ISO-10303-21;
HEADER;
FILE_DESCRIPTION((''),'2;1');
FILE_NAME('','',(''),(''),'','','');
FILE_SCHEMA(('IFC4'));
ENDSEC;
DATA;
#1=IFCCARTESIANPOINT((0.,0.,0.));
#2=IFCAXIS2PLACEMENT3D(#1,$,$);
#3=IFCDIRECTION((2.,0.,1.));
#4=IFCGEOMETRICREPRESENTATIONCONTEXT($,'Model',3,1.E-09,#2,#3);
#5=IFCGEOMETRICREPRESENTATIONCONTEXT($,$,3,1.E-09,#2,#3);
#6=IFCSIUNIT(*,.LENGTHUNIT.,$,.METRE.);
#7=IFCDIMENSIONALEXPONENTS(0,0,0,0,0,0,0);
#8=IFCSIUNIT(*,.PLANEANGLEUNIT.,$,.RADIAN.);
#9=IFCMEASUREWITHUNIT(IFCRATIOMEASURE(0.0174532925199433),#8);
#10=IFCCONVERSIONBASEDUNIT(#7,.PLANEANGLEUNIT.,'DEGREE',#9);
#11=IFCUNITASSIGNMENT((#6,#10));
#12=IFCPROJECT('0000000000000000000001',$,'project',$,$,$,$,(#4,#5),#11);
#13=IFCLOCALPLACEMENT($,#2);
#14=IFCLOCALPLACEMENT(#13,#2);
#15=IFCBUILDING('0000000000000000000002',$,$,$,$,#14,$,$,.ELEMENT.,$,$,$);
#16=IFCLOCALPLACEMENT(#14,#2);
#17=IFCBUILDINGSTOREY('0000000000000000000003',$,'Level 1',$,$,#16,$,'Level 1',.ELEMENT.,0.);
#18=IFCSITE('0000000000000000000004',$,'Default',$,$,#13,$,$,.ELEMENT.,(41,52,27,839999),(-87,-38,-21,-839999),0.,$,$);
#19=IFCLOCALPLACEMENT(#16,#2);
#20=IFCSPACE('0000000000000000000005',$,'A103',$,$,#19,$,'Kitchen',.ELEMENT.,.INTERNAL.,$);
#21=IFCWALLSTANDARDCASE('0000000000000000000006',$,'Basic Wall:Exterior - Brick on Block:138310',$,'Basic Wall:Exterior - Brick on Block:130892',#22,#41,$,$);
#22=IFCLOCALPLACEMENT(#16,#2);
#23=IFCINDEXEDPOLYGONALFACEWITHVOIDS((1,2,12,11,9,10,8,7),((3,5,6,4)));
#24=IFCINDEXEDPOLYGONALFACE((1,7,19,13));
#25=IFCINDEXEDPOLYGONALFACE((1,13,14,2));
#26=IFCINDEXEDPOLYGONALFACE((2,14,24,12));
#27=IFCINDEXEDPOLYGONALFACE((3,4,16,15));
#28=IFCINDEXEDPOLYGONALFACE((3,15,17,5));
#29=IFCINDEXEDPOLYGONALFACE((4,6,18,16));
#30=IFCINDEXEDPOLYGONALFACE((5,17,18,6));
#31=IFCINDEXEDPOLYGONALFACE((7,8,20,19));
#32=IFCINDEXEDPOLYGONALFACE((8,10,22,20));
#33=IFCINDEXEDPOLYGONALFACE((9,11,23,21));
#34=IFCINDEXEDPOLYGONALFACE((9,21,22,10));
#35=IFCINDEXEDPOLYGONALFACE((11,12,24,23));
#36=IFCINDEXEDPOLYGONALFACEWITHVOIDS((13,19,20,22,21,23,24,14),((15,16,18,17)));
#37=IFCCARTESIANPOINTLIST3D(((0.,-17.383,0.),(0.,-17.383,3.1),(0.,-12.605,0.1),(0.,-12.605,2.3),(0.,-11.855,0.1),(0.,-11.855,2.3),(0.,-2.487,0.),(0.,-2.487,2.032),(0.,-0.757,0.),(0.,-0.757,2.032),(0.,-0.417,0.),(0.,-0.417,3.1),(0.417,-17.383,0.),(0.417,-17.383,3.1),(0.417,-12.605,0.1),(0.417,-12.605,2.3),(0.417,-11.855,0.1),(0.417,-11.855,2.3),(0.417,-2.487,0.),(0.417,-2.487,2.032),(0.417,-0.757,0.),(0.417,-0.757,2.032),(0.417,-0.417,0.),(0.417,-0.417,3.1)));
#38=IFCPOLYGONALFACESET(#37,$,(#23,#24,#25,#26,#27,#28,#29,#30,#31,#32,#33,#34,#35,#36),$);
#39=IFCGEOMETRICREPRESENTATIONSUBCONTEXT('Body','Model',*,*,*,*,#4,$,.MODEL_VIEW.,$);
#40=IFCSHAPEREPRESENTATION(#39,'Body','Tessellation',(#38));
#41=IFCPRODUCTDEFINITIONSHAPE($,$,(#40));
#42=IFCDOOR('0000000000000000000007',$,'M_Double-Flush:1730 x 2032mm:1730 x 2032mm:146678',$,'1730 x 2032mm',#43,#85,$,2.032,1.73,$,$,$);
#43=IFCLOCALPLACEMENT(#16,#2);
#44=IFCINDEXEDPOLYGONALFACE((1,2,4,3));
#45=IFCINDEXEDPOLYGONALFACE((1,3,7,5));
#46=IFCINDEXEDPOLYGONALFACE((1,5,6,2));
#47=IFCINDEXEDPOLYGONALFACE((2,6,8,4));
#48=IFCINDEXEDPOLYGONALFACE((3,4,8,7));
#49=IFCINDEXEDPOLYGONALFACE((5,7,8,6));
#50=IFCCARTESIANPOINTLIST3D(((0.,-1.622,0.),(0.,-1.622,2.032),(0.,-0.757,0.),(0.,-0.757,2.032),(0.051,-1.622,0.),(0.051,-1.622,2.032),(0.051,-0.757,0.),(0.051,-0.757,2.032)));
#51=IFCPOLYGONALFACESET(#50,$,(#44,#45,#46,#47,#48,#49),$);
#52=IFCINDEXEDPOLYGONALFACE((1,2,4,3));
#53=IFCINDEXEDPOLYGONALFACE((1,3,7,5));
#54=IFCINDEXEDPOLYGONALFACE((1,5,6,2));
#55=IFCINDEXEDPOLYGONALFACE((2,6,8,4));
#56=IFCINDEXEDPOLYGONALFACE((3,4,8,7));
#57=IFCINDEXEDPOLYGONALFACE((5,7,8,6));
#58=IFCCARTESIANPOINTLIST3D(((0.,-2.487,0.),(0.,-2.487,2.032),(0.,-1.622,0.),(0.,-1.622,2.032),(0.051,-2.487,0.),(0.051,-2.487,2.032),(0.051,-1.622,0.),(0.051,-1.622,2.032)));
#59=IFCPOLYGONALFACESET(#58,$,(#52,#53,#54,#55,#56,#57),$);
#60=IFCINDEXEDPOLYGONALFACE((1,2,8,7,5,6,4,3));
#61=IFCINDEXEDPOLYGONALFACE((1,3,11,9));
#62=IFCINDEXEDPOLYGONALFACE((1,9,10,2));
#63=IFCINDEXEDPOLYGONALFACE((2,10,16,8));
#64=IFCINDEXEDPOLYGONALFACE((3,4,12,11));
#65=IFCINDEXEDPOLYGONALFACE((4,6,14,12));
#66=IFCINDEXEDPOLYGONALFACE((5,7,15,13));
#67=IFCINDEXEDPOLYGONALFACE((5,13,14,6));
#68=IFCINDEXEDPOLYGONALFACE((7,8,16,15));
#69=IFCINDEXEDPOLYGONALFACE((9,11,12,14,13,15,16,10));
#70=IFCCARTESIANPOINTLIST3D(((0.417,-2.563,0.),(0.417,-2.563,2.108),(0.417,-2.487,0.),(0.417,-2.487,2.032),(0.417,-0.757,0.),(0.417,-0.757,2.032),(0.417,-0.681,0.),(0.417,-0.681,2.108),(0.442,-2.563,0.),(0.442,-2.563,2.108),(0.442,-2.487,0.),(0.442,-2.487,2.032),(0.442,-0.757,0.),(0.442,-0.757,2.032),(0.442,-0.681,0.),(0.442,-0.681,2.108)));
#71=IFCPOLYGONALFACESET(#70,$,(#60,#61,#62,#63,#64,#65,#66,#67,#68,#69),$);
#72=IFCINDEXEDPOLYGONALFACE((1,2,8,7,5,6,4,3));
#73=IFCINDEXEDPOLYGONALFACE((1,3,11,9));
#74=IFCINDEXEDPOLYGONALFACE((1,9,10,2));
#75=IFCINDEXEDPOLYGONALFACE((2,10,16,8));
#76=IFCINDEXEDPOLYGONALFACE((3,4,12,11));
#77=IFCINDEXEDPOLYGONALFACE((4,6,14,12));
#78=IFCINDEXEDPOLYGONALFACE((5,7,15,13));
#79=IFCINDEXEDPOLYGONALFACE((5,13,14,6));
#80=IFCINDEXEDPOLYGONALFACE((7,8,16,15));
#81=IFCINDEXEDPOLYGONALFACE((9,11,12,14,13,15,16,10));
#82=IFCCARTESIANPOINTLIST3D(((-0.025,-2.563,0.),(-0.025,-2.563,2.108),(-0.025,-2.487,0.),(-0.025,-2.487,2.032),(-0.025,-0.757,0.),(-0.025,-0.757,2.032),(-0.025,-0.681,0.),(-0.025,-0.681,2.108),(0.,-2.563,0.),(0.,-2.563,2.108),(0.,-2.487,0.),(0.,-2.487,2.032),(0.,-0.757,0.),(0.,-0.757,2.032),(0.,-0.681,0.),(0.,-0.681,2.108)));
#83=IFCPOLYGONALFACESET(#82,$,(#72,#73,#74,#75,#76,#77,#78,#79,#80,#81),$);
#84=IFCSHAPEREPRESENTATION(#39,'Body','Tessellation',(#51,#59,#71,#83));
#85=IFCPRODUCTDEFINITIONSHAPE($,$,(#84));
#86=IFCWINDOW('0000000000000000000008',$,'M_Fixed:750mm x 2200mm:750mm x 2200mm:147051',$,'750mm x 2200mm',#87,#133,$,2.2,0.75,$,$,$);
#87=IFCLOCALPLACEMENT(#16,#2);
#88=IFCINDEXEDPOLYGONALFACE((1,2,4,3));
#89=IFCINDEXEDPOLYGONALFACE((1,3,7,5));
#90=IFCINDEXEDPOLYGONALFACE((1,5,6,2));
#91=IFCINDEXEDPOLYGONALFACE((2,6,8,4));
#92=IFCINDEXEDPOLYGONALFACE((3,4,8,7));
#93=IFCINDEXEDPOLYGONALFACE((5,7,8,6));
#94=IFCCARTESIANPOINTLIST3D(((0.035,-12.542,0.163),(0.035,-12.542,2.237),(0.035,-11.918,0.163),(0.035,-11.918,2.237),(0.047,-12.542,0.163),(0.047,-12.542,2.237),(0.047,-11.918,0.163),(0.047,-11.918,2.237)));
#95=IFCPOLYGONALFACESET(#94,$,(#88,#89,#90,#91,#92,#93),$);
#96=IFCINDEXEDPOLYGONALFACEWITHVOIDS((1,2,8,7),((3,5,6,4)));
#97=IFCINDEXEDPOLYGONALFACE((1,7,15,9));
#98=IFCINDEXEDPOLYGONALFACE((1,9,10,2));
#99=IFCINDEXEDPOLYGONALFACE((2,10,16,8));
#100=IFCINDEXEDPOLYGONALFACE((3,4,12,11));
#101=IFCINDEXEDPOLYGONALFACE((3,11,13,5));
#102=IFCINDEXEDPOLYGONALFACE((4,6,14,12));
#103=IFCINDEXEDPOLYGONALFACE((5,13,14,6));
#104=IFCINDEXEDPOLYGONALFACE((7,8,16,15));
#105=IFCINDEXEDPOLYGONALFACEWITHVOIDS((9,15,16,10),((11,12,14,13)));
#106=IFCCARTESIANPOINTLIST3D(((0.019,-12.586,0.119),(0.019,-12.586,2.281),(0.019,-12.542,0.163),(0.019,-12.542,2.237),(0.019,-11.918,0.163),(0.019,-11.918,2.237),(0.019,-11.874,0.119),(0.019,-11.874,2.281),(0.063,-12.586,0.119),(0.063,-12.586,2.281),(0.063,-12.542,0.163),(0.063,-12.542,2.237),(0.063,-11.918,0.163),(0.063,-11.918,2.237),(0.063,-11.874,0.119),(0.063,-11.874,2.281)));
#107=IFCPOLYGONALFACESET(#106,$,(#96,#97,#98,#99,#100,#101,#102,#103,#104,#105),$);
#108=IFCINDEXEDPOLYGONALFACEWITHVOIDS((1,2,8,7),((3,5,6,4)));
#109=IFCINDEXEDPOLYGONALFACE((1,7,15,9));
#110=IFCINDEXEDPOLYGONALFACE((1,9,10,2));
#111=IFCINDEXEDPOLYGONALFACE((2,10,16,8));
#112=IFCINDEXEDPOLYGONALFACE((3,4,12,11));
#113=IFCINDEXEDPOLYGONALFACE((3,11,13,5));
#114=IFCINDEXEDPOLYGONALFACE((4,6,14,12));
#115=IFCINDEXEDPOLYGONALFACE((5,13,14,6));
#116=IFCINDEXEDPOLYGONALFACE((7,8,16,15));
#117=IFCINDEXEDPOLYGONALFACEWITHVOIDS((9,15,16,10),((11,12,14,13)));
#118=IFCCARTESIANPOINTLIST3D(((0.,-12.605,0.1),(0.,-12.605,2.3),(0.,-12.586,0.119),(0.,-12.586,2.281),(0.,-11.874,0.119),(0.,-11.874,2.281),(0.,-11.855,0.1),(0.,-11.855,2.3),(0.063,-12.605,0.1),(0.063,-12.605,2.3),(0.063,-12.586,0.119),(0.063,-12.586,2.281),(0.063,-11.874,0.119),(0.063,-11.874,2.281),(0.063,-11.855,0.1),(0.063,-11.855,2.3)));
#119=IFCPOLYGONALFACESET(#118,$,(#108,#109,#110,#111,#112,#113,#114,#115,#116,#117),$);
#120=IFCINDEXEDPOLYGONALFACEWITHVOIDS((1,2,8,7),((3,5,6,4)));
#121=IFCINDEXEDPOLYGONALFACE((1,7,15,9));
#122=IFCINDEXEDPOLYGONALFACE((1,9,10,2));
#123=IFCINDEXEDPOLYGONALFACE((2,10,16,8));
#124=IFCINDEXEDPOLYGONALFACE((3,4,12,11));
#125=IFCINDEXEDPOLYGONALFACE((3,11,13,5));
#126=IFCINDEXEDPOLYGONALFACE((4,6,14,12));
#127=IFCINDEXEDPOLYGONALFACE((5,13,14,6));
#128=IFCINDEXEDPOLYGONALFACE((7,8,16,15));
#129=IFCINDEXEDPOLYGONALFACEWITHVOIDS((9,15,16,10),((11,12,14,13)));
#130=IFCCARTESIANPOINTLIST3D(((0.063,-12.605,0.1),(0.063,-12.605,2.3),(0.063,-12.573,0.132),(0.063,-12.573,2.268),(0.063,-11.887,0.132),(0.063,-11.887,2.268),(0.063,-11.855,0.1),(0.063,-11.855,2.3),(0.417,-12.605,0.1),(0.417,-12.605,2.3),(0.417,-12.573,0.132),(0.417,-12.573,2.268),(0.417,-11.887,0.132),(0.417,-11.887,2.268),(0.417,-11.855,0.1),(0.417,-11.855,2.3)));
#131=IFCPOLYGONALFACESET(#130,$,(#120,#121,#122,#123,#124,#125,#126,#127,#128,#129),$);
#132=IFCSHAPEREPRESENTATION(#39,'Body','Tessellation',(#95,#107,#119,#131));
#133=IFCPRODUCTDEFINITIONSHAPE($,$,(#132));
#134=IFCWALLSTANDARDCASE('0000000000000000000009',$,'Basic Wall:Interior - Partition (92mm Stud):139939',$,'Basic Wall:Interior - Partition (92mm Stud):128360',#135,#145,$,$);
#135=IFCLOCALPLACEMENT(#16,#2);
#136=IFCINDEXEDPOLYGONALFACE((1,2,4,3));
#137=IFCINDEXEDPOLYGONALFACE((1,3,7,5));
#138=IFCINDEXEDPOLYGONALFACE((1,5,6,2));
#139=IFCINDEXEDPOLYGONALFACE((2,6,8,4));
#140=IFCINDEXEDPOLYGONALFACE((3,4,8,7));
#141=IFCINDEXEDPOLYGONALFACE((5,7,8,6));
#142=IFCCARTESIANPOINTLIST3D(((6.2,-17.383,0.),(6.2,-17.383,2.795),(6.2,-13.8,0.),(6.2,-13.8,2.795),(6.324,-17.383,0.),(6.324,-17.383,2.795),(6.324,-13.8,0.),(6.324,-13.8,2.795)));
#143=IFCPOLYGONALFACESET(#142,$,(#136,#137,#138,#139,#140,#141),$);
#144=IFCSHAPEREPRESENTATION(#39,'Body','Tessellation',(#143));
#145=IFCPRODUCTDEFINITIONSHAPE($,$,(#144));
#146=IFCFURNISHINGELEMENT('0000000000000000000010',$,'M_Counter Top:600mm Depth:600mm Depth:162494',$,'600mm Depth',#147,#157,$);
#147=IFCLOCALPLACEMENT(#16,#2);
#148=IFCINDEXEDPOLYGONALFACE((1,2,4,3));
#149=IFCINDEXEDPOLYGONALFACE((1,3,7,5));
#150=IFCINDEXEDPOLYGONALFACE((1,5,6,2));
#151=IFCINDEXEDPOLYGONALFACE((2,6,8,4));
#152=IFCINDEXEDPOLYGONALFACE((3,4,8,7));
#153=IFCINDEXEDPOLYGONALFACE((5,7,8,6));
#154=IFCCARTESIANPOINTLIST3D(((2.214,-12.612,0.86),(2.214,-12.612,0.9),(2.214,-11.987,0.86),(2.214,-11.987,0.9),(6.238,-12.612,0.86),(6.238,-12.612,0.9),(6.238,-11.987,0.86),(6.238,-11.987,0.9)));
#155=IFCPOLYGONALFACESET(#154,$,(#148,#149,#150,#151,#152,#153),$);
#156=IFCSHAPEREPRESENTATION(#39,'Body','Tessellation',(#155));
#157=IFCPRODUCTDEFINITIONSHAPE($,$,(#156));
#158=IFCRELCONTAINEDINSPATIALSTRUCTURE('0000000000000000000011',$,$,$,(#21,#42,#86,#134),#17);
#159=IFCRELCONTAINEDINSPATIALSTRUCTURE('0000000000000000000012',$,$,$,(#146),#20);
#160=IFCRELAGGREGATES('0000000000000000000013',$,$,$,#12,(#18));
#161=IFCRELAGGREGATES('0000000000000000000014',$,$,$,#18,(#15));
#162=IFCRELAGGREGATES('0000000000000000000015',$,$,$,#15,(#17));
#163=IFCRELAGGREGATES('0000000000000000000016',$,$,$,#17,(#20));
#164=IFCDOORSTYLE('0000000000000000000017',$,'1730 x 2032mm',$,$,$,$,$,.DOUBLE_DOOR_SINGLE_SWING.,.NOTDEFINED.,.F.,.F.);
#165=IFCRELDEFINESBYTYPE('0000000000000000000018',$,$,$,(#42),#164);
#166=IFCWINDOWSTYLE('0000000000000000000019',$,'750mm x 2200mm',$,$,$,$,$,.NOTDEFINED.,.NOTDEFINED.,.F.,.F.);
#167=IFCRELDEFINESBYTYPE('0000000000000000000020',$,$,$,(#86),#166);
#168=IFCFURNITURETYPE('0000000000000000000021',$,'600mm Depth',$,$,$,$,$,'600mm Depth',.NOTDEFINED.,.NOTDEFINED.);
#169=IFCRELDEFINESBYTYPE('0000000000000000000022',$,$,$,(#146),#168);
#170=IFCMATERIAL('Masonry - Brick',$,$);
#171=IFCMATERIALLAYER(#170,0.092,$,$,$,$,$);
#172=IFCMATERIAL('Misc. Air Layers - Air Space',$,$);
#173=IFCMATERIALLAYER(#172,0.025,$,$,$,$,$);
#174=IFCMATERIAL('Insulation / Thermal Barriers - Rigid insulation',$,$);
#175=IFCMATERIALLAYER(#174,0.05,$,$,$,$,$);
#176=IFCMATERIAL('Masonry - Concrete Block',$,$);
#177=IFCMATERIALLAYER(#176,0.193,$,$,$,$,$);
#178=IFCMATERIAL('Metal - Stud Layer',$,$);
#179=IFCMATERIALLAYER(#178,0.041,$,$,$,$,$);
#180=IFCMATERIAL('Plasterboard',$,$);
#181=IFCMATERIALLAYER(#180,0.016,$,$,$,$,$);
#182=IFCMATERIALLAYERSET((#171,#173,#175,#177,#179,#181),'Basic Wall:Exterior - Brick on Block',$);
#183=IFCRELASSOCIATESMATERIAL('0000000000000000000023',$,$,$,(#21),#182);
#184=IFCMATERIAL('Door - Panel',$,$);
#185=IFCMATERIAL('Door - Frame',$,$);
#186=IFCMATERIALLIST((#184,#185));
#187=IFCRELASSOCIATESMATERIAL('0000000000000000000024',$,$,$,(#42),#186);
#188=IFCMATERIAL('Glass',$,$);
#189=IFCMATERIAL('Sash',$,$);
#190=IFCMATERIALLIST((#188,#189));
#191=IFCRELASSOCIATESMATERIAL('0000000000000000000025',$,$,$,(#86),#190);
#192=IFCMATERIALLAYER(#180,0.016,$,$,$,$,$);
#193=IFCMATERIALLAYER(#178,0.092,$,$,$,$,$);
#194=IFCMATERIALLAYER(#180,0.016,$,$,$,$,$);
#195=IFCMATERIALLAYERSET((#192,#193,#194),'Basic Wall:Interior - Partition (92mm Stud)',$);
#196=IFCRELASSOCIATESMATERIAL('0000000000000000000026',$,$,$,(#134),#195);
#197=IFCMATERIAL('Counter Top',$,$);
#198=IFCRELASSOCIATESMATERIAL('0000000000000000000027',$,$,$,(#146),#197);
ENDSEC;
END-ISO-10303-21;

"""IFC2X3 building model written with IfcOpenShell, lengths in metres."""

from ifc_helpers import new_model, entity, si_unit, converted_unit, direction, frame, frame_2d, origin, origin_2d_with_axis, place, context, subcontext, project, spatial, polyline, rectangle, outline, extrude, source, transform, mapped, material, material_list, layer, layer_set, layer_usage, type_object, type_shapes, element, fill, save


model = new_model("IFC2X3")

# Units and contexts
model_context = context("Model", 3, precision=1e-09, world=origin(), true_north=direction((2.0, 0.0, 1.0)))
context_of_model = context(None, 3, precision=1e-09, world=origin(), true_north=direction((2.0, 0.0, 1.0)))
body_context = subcontext(model_context, "Body", "Model", "MODEL_VIEW")
ifc_project = project(units=[si_unit("LENGTHUNIT", "METRE"), converted_unit("PLANEANGLEUNIT", "DEGREE", entity("IfcRatioMeasure", 0.0174532925199433), si_unit("PLANEANGLEUNIT", "RADIAN"), dimensions=[0, 0, 0, 0, 0, 0, 0])], contexts=[model_context, context_of_model])

# Site, building, storey
site_placement = place(None, origin())
site = spatial("IfcSite", under=ifc_project, at=site_placement, Name="Default", CompositionType="ELEMENT", RefLatitude=(41, 52, 27, 839999), RefLongitude=(-87, -38, -21, -839999), RefElevation=0.0)
building_placement = place(site_placement, origin())
building = spatial("IfcBuilding", under=site, at=building_placement, CompositionType="ELEMENT")
storey_placement = place(building_placement, origin())
storey = spatial("IfcBuildingStorey", under=building, at=storey_placement, Name="Level 1", LongName="Level 1", CompositionType="ELEMENT", Elevation=0.0)

# Shared definitions
ifc_material_1 = material(Name="Masonry - Brick")
ifc_layer_1 = layer(ifc_material_1, 0.092)
ifc_material_2 = material(Name="Misc. Air Layers - Air Space")
ifc_layer_2 = layer(ifc_material_2, 0.025)
ifc_material_3 = material(Name="Insulation / Thermal Barriers - Rigid insulation")
ifc_layer_3 = layer(ifc_material_3, 0.05)
ifc_material_4 = material(Name="Masonry - Concrete Block")
ifc_layer_4 = layer(ifc_material_4, 0.193)
ifc_material_5 = material(Name="Metal - Stud Layer")
ifc_layer_5 = layer(ifc_material_5, 0.041)
ifc_material_6 = material(Name="Plasterboard")
ifc_layer_6 = layer(ifc_material_6, 0.016)
ifc_layer_set_1 = layer_set([ifc_layer_1, ifc_layer_2, ifc_layer_3, ifc_layer_4, ifc_layer_5, ifc_layer_6], Name="Basic Wall:Exterior - Brick on Block")
ifc_material_7 = material(Name="Glass")
ifc_material_8 = material(Name="Sash")
ifc_material_9 = material(Name="Door - Frame")
ifc_material_10 = material(Name="Door - Panel")

# Wall, openings, door, window
ifc_layer_usage_1 = layer_usage(ifc_layer_set_1, "AXIS2", "NEGATIVE", 0.2085)
wall_1_placement = place(storey_placement, frame((0.2085, -17.383, 0.0), z_axis=(0.0, 0.0, 1.0), x_axis=(0.0, 1.0, 0.0)))
wall_1 = element("IfcWallStandardCase", 1, at=wall_1_placement, inside=storey, material=ifc_layer_usage_1, Name="Basic Wall:Exterior - Brick on Block:138310", ObjectType="Basic Wall:Exterior - Brick on Block:130892", context=body_context, shape_type="SweptSolid", body=[
    extrude(rectangle(XDim=16.966, YDim=0.417, at=frame_2d((8.483, 0.0), x_axis=(-1.0, 0.0))), origin(), (0.0, 0.0, 1.0), 3.1),
])
opening_1_placement = place(wall_1_placement, frame((14.896, -0.2085, 0.0)))
opening_1 = element("IfcOpeningElement", 2, at=opening_1_placement, cuts=wall_1, ObjectType="Opening", context=body_context, shape_type="SweptSolid", body=[
    extrude(rectangle(XDim=2.032, YDim=1.73, at=frame_2d((1.016, 0.865), x_axis=(1.0, 0.0))), frame((0.0, 0.0, 0.0), z_axis=(0.0, 1.0, 0.0), x_axis=(0.0, 0.0, 1.0)), (0.0, 0.0, 1.0), 0.417),
])
opening_2_placement = place(wall_1_placement, frame((4.778, -0.2085, 0.1)))
opening_2 = element("IfcOpeningElement", 3, at=opening_2_placement, cuts=wall_1, ObjectType="Opening", context=body_context, shape_type="SweptSolid", body=[
    extrude(rectangle(XDim=2.2, YDim=0.75, at=frame_2d((1.1, 0.375), x_axis=(1.0, 0.0))), frame((0.0, 0.0, 0.0), z_axis=(0.0, 1.0, 0.0), x_axis=(0.0, 0.0, 1.0)), (0.0, 0.0, 1.0), 0.417),
])
ifc_material_list_1 = material_list([ifc_material_10, ifc_material_9])
door_style_1 = type_object("IfcDoorStyle", Name="1730 x 2032mm", ConstructionType="NOTDEFINED", OperationType="DOUBLE_DOOR_SINGLE_SWING", ParameterTakesPrecedence=False, Sizeable=False)
shared_shape_1 = source(origin(), body_context, "Body", "SweptSolid", [
    extrude(rectangle(XDim=0.051, YDim=0.865, at=frame_2d((0.0, 0.0), x_axis=(1.0, 0.0))), frame((1.2975, 0.3915, 0.0), z_axis=(0.0, 0.0, 1.0), x_axis=(0.0, -1.0, 0.0)), (0.0, 0.0, 1.0), 2.032),
    extrude(rectangle(XDim=0.051, YDim=0.865, at=frame_2d((0.0, 0.0), x_axis=(1.0, 0.0))), frame((0.4325, 0.3915, 0.0), z_axis=(0.0, 0.0, 1.0), x_axis=(0.0, -1.0, 0.0)), (0.0, 0.0, 1.0), 2.032),
    extrude(outline(polyline([(-0.997, 0.865), (1.035, 0.865), (1.035, 0.941), (-1.073, 0.941), (-1.073, -0.941), (1.035, -0.941), (1.035, -0.865), (-0.997, -0.865), (-0.997, 0.865)])), frame((0.865, -0.025, 1.035), z_axis=(0.0, 1.0, 0.0), x_axis=(0.0, 0.0, -1.0)), (0.0, 0.0, 1.0), 0.025),
    extrude(outline(polyline([(-0.997, 0.865), (1.035, 0.865), (1.035, 0.941), (-1.073, 0.941), (-1.073, -0.941), (1.035, -0.941), (1.035, -0.865), (-0.997, -0.865), (-0.997, 0.865)])), frame((0.865, 0.417, 1.035), z_axis=(0.0, 1.0, 0.0), x_axis=(0.0, 0.0, -1.0)), (0.0, 0.0, 1.0), 0.025),
])
type_shapes(door_style_1, [shared_shape_1])
door_1_placement = place(opening_1_placement, origin())
door_1 = element("IfcDoor", 4, at=door_1_placement, inside=storey, type_object=door_style_1, material=ifc_material_list_1, Name="M_Double-Flush:1730 x 2032mm:1730 x 2032mm:146678", ObjectType="1730 x 2032mm", OverallHeight=2.032, OverallWidth=1.73, context=body_context, shape_type="MappedRepresentation", body=[
    mapped(shared_shape_1, transform((0.0, 0.0, 0.0), scale=1.0)),
])
fill(opening_1, door_1)
ifc_material_list_2 = material_list([ifc_material_7, ifc_material_8])
window_style_1 = type_object("IfcWindowStyle", Name="750mm x 2200mm", ConstructionType="NOTDEFINED", OperationType="NOTDEFINED", ParameterTakesPrecedence=False, Sizeable=False)
shared_shape_2 = source(origin(), body_context, "Body", "SweptSolid", [
    extrude(rectangle(XDim=0.012, YDim=0.624, at=origin_2d_with_axis()), frame((0.375, 0.376, 0.063), z_axis=(0.0, 0.0, 1.0), x_axis=(0.0, -1.0, 0.0)), (0.0, 0.0, 1.0), 2.074),
    extrude(outline(polyline([(-0.356, -1.081), (0.356, -1.081), (0.356, 1.081), (-0.356, 1.081), (-0.356, -1.081)]), holes=[polyline([(-0.312, -1.037), (-0.312, 1.037), (0.312, 1.037), (0.312, -1.037), (-0.312, -1.037)])]), frame((0.375, 0.354, 1.1), z_axis=(0.0, 1.0, 0.0), x_axis=(1.0, 0.0, 0.0)), (0.0, 0.0, 1.0), 0.044),
    extrude(outline(polyline([(-0.375, -1.1), (0.375, -1.1), (0.375, 1.1), (-0.375, 1.1), (-0.375, -1.1)]), holes=[polyline([(-0.356, -1.081), (-0.356, 1.081), (0.356, 1.081), (0.356, -1.081), (-0.356, -1.081)])]), frame((0.375, 0.354, 1.1), z_axis=(0.0, 1.0, 0.0), x_axis=(1.0, 0.0, 0.0)), (0.0, 0.0, 1.0), 0.063),
    extrude(outline(polyline([(-0.375, -1.1), (0.375, -1.1), (0.375, 1.1), (-0.375, 1.1), (-0.375, -1.1)]), holes=[polyline([(-0.343, -1.068), (-0.343, 1.068), (0.343, 1.068), (0.343, -1.068), (-0.343, -1.068)])]), frame((0.375, 0.0, 1.1), z_axis=(0.0, 1.0, 0.0), x_axis=(1.0, 0.0, 0.0)), (0.0, 0.0, 1.0), 0.354),
])
type_shapes(window_style_1, [shared_shape_2])
window_1_placement = place(opening_2_placement, origin())
window_1 = element("IfcWindow", 5, at=window_1_placement, inside=storey, type_object=window_style_1, material=ifc_material_list_2, Name="M_Fixed:750mm x 2200mm:750mm x 2200mm:147051", ObjectType="750mm x 2200mm", OverallHeight=2.2, OverallWidth=0.75, context=body_context, shape_type="MappedRepresentation", body=[
    mapped(shared_shape_2, transform((0.0, 0.0, 0.0), scale=1.0)),
])
fill(opening_2, window_1)

# Wall
ifc_layer_7 = layer(ifc_material_6, 0.016)
ifc_layer_8 = layer(ifc_material_5, 0.092)
ifc_layer_9 = layer(ifc_material_6, 0.016)
ifc_layer_set_2 = layer_set([ifc_layer_7, ifc_layer_8, ifc_layer_9], Name="Basic Wall:Interior - Partition (92mm Stud)")
ifc_layer_usage_2 = layer_usage(ifc_layer_set_2, "AXIS2", "NEGATIVE", 0.062)
wall_2_placement = place(storey_placement, frame((6.262, -13.8, 0.0), z_axis=(0.0, 0.0, 1.0), x_axis=(0.0, -1.0, 0.0)))
element("IfcWallStandardCase", 6, at=wall_2_placement, inside=storey, material=ifc_layer_usage_2, Name="Basic Wall:Interior - Partition (92mm Stud):139939", ObjectType="Basic Wall:Interior - Partition (92mm Stud):128360", context=body_context, shape_type="SweptSolid", body=[
    extrude(rectangle(XDim=3.583, YDim=0.124, at=frame_2d((1.7915, 0.0), x_axis=(-1.0, 0.0))), origin(), (0.0, 0.0, 1.0), 2.795),
])

# Shared definitions
space_1_placement = place(storey_placement, origin())
space_1 = spatial("IfcSpace", under=storey, at=space_1_placement, Name="A103", LongName="Kitchen", CompositionType="ELEMENT", InteriorOrExteriorSpace="INTERNAL")

# Furnishing element
ifc_material_11 = material(Name="Counter Top")
furniture_type_1 = type_object("IfcFurnitureType", Name="600mm Depth", ElementType="600mm Depth", AssemblyPlace="NOTDEFINED")
shared_shape_3 = source(origin(), body_context, "Body", "SweptSolid", [
    extrude(rectangle(XDim=4.024, YDim=0.625, at=frame_2d((0.0, 0.0), x_axis=(1.0, 0.0))), frame((0.8115, -0.3125, 0.86), z_axis=(0.0, 0.0, 1.0), x_axis=(-1.0, 0.0, 0.0)), (0.0, 0.0, 1.0), 0.04),
])
type_shapes(furniture_type_1, [shared_shape_3])
furnishing_1_placement = place(space_1_placement, frame((5.0375, -12.612, 0.0), z_axis=(0.0, 0.0, 1.0), x_axis=(-1.0, 0.0, 0.0)))
element("IfcFurnishingElement", 7, at=furnishing_1_placement, inside=space_1, type_object=furniture_type_1, material=ifc_material_11, Name="M_Counter Top:600mm Depth:600mm Depth:162494", ObjectType="600mm Depth", context=body_context, shape_type="MappedRepresentation", body=[
    mapped(shared_shape_3, transform((0.0, 0.0, 0.0), scale=1.0)),
])

save(model, "model.ifc")
